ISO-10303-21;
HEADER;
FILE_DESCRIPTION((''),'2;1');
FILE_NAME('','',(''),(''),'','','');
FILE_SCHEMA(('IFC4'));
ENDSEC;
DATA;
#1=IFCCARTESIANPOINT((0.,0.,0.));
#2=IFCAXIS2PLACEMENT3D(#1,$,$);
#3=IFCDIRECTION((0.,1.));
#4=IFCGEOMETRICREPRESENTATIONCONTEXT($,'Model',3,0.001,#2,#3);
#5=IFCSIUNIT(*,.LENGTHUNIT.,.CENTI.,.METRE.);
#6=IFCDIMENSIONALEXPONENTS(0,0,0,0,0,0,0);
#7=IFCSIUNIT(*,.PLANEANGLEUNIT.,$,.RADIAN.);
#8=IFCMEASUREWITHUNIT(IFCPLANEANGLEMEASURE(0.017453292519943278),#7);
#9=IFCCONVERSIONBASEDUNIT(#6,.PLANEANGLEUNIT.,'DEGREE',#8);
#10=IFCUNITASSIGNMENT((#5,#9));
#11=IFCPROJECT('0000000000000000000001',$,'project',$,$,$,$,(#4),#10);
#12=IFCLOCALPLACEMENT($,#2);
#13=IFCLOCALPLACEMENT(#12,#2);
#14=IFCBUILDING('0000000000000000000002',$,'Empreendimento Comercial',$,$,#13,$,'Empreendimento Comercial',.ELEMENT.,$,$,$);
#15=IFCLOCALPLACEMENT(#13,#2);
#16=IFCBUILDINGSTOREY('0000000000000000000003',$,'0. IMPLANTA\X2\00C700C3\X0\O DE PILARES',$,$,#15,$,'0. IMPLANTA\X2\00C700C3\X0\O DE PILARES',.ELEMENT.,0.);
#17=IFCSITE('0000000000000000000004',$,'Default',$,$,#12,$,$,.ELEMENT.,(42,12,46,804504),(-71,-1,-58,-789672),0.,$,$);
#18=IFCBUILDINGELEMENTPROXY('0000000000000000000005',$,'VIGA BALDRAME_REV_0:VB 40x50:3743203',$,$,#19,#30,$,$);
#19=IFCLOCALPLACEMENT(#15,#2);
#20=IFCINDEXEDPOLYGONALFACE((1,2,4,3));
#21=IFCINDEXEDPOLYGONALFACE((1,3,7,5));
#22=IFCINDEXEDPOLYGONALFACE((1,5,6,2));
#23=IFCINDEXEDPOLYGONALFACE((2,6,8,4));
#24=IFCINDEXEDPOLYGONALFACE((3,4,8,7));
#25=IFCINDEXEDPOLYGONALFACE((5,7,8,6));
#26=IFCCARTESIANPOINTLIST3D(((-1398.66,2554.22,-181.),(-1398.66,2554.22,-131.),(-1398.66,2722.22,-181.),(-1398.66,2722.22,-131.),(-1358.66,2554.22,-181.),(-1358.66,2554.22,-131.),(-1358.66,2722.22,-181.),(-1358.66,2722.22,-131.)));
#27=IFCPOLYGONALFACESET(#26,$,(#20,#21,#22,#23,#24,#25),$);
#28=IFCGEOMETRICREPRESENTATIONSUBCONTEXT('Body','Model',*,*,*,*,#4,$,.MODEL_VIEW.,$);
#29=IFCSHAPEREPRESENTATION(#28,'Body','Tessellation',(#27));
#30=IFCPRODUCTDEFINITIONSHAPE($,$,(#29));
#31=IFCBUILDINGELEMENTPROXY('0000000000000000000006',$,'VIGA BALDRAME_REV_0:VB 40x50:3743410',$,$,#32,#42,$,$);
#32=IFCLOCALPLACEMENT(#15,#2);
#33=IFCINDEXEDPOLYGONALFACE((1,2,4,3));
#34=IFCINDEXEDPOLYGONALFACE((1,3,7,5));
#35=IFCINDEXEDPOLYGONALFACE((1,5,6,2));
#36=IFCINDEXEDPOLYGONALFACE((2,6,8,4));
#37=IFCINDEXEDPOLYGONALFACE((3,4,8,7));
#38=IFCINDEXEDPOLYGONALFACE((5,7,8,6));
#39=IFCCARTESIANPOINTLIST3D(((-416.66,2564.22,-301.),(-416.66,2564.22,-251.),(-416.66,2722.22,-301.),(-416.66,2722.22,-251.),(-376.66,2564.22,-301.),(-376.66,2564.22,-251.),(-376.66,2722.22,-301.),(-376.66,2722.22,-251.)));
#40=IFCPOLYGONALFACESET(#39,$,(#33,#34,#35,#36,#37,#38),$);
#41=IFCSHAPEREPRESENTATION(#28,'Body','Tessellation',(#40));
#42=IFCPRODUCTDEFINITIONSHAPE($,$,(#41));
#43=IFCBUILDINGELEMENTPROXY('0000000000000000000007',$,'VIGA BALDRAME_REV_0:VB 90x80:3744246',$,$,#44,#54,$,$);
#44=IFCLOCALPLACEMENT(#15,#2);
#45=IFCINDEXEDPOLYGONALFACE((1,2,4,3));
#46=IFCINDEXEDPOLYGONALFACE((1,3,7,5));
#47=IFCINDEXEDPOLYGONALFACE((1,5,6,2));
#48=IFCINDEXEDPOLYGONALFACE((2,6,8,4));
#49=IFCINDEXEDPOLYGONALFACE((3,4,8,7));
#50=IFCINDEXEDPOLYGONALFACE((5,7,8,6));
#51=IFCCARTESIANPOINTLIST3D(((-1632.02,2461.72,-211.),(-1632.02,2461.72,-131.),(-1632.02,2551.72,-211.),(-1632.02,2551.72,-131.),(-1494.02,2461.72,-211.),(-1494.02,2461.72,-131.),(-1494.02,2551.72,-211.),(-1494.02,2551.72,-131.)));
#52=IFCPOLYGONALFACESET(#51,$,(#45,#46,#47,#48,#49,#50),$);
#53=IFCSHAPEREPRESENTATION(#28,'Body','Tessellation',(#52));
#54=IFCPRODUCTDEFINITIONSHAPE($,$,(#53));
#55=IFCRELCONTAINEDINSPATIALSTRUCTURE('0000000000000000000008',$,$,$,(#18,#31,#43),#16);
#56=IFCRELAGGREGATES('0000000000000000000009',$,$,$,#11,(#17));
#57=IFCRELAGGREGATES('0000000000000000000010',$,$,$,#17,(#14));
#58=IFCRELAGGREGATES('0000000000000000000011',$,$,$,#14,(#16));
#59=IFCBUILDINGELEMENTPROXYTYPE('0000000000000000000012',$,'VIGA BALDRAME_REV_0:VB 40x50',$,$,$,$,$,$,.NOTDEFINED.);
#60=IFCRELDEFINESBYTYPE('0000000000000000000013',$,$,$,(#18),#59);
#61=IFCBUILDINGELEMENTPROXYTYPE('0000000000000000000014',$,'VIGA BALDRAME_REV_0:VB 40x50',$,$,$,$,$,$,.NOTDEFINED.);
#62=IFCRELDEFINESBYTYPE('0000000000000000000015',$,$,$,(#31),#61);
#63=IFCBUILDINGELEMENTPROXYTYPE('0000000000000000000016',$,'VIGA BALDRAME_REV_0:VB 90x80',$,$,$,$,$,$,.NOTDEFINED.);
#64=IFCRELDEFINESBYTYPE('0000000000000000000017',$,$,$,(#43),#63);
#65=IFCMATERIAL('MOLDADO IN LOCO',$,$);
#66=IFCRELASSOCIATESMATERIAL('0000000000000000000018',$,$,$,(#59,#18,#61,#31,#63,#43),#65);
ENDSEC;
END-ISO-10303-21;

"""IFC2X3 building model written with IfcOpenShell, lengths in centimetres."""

from ifc_helpers import new_model, entity, si_unit, converted_unit, direction, frame, frame_2d, origin, place, context, subcontext, project, spatial, rectangle, extrude, source, transform, mapped, material, type_object, type_shapes, element, save


model = new_model("IFC2X3")

# Units and contexts
model_context = context("Model", 3, precision=0.001, world=origin(), true_north=direction((0.0, 1.0)))
body_context = subcontext(model_context, "Body", "Model", "MODEL_VIEW")
ifc_project = project(units=[si_unit("LENGTHUNIT", "METRE", prefix="CENTI"), converted_unit("PLANEANGLEUNIT", "DEGREE", entity("IfcPlaneAngleMeasure", 0.017453292519943278), si_unit("PLANEANGLEUNIT", "RADIAN"), dimensions=[0, 0, 0, 0, 0, 0, 0])], contexts=[model_context])

# Site, building, storey
site_placement = place(None, origin())
site = spatial("IfcSite", under=ifc_project, at=site_placement, Name="Default", CompositionType="ELEMENT", RefLatitude=(42, 12, 46, 804504), RefLongitude=(-71, -1, -58, -789672), RefElevation=0.0)
building_placement = place(site_placement, origin())
building = spatial("IfcBuilding", under=site, at=building_placement, Name="Empreendimento Comercial", LongName="Empreendimento Comercial", CompositionType="ELEMENT")
storey_placement = place(building_placement, origin())
storey = spatial("IfcBuildingStorey", under=building, at=storey_placement, Name="0. IMPLANTAÇÃO DE PILARES", LongName="0. IMPLANTAÇÃO DE PILARES", CompositionType="ELEMENT", Elevation=0.0)

# Shared definitions
ifc_material_1 = material(Name="MOLDADO IN LOCO")

# Building element proxies
building_element_proxy_type_1 = type_object("IfcBuildingElementProxyType", Name="VIGA BALDRAME_REV_0:VB 40x50", PredefinedType="NOTDEFINED", material=ifc_material_1)
shared_shape_1 = source(origin(), body_context, "Body", "SweptSolid", [
    extrude(rectangle(XDim=168.0, YDim=40.0, at=frame_2d((0.0, 0.0), x_axis=(1.0, 0.0))), frame((-1378.66, 2638.22, -181.0), z_axis=(0.0, 0.0, 1.0), x_axis=(0.0, -1.0, 0.0)), (0.0, 0.0, 1.0), 50.0),
])
type_shapes(building_element_proxy_type_1, [shared_shape_1])
proxy_1_placement = place(storey_placement, origin())
element("IfcBuildingElementProxy", 1, at=proxy_1_placement, inside=storey, type_object=building_element_proxy_type_1, material=ifc_material_1, Name="VIGA BALDRAME_REV_0:VB 40x50:3743203", context=body_context, shape_type="MappedRepresentation", body=[
    mapped(shared_shape_1, transform((0.0, 0.0, 0.0), scale=1.0)),
])
building_element_proxy_type_2 = type_object("IfcBuildingElementProxyType", Name="VIGA BALDRAME_REV_0:VB 40x50", PredefinedType="NOTDEFINED", material=ifc_material_1)
shared_shape_2 = source(origin(), body_context, "Body", "SweptSolid", [
    extrude(rectangle(XDim=158.0, YDim=40.0, at=frame_2d((0.0, 0.0), x_axis=(1.0, 0.0))), frame((-396.66, 2643.22, -301.0), z_axis=(0.0, 0.0, 1.0), x_axis=(0.0, -1.0, 0.0)), (0.0, 0.0, 1.0), 50.0),
])
type_shapes(building_element_proxy_type_2, [shared_shape_2])
proxy_2_placement = place(storey_placement, origin())
element("IfcBuildingElementProxy", 2, at=proxy_2_placement, inside=storey, type_object=building_element_proxy_type_2, material=ifc_material_1, Name="VIGA BALDRAME_REV_0:VB 40x50:3743410", context=body_context, shape_type="MappedRepresentation", body=[
    mapped(shared_shape_2, transform((0.0, 0.0, 0.0), scale=1.0)),
])
building_element_proxy_type_3 = type_object("IfcBuildingElementProxyType", Name="VIGA BALDRAME_REV_0:VB 90x80", PredefinedType="NOTDEFINED", material=ifc_material_1)
shared_shape_3 = source(origin(), body_context, "Body", "SweptSolid", [
    extrude(rectangle(XDim=90.0, YDim=138.0, at=frame_2d((0.0, 0.0), x_axis=(1.0, 0.0))), frame((-1563.02, 2506.72, -211.0), z_axis=(0.0, 0.0, 1.0), x_axis=(0.0, -1.0, 0.0)), (0.0, 0.0, 1.0), 80.0),
])
type_shapes(building_element_proxy_type_3, [shared_shape_3])
proxy_3_placement = place(storey_placement, origin())
element("IfcBuildingElementProxy", 3, at=proxy_3_placement, inside=storey, type_object=building_element_proxy_type_3, material=ifc_material_1, Name="VIGA BALDRAME_REV_0:VB 90x80:3744246", context=body_context, shape_type="MappedRepresentation", body=[
    mapped(shared_shape_3, transform((0.0, 0.0, 0.0), scale=1.0)),
])

save(model, "model.ifc")
